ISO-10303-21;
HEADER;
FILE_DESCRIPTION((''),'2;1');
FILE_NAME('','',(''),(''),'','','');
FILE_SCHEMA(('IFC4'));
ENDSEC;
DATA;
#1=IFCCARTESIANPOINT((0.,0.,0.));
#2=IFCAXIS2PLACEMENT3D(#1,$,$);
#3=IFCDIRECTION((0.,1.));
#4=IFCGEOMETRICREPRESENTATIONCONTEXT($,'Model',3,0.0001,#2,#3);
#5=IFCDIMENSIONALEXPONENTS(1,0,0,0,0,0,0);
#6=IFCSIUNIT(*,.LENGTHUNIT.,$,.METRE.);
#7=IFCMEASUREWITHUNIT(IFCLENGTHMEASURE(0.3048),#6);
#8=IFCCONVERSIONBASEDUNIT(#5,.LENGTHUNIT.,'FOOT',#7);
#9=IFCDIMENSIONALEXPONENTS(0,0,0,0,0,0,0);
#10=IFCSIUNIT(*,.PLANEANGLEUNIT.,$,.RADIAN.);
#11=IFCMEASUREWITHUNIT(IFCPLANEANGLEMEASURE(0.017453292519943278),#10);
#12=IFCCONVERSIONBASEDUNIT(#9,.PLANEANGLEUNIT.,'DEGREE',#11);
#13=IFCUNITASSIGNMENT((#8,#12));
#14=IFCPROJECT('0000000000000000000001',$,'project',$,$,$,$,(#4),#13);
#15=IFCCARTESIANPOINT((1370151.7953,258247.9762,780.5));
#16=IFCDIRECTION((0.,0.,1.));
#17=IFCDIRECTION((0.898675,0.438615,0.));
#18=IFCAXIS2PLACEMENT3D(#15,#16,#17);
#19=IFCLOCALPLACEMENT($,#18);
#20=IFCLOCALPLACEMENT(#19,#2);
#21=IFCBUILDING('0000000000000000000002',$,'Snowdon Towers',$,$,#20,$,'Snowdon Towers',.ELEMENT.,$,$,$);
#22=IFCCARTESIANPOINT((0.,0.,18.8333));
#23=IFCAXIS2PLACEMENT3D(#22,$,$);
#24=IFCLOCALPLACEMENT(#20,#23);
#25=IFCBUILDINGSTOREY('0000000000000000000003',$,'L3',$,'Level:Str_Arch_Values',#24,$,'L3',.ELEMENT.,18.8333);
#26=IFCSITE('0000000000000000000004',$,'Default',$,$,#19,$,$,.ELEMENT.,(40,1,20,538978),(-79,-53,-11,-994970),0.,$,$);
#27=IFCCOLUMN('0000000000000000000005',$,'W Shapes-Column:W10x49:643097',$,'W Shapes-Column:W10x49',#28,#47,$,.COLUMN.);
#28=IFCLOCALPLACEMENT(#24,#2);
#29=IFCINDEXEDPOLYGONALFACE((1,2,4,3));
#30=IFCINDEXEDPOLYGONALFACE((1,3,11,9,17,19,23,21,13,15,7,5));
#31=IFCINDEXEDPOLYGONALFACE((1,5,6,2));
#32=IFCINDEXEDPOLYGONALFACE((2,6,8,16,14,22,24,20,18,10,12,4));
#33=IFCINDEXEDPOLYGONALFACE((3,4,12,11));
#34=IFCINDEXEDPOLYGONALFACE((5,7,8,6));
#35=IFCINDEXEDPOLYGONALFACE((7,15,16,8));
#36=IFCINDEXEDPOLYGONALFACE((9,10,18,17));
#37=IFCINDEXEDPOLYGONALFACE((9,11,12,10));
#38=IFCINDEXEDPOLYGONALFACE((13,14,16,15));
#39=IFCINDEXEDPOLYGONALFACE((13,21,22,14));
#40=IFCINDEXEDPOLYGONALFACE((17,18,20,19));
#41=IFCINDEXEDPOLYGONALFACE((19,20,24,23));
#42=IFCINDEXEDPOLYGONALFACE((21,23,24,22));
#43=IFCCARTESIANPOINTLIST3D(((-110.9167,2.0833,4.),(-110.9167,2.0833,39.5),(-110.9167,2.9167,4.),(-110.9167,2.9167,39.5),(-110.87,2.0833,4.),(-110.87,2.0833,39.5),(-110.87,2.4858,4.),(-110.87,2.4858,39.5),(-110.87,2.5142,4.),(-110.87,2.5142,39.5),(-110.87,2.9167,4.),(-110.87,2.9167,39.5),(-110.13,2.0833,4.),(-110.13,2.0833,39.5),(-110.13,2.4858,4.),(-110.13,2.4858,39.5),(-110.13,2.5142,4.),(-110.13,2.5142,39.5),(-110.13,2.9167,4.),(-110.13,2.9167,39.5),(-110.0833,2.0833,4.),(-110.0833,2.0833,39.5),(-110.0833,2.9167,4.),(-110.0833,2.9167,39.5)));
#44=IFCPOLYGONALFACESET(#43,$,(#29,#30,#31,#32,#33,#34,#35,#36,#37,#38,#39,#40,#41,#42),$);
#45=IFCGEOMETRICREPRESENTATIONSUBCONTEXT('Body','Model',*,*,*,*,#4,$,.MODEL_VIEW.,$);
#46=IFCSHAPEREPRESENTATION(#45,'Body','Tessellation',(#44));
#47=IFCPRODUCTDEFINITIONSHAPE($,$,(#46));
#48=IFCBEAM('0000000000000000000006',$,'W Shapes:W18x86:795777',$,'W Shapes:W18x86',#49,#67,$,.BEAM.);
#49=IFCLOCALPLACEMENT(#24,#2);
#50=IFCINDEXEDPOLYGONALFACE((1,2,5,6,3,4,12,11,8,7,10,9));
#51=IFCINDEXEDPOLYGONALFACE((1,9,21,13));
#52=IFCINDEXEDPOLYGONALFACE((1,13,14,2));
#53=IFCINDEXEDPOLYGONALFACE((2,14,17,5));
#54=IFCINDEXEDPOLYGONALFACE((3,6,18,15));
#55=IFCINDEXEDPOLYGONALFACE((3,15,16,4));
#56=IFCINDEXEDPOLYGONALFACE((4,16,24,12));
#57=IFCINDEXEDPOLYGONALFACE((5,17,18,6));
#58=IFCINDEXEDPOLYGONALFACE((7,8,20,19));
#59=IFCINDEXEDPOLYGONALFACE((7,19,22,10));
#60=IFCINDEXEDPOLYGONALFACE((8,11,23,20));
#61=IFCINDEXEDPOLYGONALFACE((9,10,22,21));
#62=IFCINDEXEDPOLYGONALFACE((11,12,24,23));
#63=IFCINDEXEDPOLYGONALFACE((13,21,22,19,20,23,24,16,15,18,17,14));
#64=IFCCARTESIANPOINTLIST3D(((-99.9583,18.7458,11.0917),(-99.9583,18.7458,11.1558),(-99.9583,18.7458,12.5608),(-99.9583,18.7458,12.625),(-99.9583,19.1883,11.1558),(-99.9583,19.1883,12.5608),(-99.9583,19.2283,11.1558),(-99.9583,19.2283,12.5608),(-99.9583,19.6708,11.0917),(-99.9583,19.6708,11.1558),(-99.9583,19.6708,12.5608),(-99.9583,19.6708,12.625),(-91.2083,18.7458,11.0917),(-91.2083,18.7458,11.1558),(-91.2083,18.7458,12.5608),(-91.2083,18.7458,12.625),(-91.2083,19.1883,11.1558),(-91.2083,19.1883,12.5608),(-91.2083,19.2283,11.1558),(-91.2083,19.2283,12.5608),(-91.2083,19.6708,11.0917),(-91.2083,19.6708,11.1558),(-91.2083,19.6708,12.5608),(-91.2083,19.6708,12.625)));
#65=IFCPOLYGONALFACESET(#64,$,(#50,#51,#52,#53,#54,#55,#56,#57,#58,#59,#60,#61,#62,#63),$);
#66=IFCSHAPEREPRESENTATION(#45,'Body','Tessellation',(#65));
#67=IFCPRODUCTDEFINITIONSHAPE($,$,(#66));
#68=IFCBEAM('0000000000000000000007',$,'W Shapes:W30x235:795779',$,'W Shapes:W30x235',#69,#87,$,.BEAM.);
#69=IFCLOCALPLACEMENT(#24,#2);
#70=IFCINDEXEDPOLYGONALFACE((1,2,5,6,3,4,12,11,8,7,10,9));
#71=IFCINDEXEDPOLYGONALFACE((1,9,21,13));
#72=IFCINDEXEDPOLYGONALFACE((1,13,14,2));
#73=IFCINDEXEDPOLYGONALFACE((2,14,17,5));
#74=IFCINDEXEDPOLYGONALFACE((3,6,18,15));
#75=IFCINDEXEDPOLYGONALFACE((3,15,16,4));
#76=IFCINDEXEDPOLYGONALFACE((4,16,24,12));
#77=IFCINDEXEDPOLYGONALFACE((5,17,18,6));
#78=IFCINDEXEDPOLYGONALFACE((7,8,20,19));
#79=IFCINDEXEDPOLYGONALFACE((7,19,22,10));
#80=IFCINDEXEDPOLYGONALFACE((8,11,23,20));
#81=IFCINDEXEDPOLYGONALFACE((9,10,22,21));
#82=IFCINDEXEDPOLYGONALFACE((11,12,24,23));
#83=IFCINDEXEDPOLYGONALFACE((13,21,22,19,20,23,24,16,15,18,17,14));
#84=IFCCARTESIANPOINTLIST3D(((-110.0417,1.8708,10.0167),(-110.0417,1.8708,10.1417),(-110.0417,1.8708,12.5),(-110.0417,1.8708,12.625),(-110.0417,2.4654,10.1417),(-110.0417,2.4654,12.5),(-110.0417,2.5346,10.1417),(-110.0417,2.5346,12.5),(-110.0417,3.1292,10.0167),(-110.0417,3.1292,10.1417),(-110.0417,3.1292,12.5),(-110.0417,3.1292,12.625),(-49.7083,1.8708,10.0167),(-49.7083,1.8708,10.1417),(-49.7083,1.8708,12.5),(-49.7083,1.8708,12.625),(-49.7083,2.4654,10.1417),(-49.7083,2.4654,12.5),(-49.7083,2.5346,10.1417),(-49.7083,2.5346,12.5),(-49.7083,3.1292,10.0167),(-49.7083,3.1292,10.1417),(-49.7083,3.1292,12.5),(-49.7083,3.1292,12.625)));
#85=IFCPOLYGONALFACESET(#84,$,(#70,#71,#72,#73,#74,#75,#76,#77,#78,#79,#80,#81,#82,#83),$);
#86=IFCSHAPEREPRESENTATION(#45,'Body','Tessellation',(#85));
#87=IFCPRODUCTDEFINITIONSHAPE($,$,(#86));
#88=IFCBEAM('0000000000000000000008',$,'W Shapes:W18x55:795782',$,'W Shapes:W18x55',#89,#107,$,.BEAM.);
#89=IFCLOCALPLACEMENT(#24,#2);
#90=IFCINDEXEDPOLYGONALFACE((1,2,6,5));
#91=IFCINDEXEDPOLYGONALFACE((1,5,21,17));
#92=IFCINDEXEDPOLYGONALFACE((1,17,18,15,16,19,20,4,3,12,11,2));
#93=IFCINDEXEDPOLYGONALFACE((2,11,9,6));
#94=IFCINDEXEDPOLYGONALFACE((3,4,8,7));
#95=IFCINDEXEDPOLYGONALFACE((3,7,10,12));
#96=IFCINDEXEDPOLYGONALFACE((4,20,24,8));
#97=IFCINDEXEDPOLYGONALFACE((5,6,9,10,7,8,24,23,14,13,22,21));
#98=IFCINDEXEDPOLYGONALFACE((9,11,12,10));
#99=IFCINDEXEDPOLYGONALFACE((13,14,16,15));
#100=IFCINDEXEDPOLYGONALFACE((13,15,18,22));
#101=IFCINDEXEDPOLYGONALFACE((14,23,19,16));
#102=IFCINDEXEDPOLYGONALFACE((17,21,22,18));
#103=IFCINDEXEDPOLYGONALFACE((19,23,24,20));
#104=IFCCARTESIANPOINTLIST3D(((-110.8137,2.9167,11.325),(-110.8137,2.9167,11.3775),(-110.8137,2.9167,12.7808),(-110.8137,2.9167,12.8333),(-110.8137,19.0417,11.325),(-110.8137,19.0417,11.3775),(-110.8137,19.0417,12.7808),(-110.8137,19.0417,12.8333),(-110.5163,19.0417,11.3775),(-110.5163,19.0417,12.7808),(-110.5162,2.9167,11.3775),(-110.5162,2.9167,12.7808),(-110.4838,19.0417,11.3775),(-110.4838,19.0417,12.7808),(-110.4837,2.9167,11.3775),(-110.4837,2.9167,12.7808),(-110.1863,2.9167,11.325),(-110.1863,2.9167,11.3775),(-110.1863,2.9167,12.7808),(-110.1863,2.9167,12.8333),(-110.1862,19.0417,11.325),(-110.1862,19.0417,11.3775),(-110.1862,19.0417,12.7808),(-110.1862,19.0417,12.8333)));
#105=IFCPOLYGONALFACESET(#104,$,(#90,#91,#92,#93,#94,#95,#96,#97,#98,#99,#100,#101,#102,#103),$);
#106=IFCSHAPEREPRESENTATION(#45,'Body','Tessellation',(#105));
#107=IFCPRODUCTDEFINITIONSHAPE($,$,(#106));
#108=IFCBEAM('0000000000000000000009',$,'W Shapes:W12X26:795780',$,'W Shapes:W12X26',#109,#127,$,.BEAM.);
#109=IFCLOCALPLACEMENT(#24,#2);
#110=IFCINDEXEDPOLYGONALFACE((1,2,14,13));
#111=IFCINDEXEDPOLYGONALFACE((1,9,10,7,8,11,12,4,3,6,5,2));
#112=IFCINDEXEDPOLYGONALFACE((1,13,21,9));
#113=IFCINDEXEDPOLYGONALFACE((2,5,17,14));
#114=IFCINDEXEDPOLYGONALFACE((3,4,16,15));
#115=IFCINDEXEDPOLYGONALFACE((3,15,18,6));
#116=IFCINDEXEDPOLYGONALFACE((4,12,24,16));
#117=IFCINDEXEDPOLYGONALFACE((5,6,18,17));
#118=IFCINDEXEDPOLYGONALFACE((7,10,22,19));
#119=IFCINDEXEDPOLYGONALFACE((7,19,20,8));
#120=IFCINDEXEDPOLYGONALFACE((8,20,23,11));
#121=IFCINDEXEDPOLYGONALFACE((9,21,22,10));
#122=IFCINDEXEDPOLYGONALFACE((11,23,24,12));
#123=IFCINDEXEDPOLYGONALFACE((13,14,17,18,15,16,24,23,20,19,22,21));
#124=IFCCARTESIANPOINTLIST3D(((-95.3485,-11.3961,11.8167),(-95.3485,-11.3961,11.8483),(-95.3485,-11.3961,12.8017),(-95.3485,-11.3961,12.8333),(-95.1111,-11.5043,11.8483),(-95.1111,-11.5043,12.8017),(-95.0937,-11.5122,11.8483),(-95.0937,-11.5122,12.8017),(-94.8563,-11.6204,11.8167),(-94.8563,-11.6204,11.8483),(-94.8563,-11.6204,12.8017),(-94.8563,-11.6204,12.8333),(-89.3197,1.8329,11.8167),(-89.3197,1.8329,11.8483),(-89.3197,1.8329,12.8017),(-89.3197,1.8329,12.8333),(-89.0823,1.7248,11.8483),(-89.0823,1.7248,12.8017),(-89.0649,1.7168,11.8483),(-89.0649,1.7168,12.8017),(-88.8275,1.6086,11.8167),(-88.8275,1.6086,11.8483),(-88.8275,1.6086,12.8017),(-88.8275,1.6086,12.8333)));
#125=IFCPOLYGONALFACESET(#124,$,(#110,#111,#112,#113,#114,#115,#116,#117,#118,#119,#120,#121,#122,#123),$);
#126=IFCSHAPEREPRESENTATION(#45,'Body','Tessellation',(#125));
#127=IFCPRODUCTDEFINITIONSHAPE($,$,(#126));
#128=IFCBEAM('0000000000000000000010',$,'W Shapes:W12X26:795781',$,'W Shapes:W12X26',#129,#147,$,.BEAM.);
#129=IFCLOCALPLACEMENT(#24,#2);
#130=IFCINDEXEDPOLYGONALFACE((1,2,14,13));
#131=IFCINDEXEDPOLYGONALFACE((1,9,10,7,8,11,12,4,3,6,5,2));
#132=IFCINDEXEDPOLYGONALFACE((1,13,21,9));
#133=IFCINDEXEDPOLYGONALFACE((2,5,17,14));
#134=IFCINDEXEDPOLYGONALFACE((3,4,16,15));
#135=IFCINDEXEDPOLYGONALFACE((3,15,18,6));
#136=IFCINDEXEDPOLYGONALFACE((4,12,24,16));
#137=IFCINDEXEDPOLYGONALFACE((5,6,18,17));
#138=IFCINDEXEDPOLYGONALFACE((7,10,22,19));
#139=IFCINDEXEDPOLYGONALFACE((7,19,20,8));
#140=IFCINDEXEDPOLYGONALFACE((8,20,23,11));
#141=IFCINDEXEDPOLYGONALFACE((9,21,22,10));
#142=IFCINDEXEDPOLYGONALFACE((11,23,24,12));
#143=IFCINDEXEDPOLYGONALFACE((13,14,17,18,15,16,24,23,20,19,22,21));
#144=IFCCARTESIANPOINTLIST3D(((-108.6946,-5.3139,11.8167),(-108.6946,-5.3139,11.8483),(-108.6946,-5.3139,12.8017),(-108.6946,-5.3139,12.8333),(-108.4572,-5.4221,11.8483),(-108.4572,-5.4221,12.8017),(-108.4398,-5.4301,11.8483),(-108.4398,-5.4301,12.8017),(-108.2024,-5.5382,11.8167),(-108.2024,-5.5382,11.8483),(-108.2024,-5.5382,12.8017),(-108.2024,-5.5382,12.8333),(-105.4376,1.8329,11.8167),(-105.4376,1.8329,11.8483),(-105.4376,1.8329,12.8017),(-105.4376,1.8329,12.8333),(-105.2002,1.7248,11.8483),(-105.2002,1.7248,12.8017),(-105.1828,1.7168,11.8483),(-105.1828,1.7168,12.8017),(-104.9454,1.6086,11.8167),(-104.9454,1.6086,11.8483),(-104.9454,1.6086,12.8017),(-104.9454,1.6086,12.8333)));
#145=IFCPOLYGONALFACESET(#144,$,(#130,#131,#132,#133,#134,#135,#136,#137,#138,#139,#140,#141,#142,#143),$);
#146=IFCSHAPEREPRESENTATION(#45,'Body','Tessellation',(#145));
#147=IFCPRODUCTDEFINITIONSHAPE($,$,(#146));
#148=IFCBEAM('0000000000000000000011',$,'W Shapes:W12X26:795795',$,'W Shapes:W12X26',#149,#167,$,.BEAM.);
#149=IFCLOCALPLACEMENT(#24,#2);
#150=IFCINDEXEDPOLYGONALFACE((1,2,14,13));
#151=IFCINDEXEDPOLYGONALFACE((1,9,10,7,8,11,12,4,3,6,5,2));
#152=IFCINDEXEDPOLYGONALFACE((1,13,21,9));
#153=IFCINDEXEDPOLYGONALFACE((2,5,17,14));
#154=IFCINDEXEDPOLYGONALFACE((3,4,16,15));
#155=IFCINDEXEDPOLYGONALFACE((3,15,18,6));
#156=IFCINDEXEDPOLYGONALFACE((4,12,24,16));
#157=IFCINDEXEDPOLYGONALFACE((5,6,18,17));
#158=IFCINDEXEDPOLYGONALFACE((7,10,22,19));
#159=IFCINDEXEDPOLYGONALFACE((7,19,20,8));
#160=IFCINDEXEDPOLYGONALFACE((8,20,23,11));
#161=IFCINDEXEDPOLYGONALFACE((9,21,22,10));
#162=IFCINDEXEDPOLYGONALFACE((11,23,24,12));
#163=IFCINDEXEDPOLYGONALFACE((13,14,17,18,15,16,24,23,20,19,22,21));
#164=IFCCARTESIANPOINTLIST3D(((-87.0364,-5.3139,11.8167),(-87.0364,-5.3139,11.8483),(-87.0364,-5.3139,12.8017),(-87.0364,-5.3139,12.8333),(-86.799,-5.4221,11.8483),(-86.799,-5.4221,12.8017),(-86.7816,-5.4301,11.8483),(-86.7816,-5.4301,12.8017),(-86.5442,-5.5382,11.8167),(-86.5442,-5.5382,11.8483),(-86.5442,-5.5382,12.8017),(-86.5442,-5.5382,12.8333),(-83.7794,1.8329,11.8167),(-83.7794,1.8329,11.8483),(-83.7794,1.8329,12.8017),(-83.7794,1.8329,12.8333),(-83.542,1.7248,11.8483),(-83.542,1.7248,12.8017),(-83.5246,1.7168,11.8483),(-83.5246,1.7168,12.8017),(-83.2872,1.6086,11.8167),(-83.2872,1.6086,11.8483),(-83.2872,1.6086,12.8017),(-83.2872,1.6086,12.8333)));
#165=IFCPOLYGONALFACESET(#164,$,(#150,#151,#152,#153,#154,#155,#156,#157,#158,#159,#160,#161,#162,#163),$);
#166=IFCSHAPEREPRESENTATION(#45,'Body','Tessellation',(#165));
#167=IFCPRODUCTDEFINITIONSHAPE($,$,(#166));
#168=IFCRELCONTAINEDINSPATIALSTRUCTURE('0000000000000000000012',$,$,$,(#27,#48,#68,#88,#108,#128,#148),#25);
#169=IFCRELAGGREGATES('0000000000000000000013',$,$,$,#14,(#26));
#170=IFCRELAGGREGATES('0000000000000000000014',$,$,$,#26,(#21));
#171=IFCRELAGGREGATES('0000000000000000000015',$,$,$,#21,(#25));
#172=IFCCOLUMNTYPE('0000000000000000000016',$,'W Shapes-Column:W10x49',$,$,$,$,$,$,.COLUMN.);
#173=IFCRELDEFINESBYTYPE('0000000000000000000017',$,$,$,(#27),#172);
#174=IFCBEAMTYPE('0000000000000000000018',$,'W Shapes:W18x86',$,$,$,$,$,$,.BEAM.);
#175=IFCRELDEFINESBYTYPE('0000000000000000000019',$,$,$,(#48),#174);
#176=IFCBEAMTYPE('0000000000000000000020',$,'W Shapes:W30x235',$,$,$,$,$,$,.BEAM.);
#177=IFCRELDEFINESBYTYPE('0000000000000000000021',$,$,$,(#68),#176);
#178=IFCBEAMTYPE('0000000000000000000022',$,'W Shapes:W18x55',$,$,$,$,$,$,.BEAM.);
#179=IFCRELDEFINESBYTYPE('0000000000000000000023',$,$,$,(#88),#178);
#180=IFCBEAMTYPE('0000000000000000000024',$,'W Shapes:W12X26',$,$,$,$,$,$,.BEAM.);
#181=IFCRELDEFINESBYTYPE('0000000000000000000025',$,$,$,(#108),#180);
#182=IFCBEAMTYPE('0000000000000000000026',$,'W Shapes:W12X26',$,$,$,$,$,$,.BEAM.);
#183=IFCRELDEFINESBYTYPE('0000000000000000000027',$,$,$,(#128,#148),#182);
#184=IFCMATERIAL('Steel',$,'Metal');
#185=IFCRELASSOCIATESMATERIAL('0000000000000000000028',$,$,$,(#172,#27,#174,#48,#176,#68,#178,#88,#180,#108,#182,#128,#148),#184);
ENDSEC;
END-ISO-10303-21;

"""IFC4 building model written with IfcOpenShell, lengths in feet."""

from ifc_helpers import new_model, entity, si_unit, converted_unit, direction, frame, origin, place, context, subcontext, project, spatial, indexed_curve, outline, extrude, source, transform, mapped, material, type_object, type_shapes, element, save


model = new_model("IFC4")

# Units and contexts
model_context = context("Model", 3, precision=0.0001, world=origin(), true_north=direction((0.0, 1.0)))
body_context = subcontext(model_context, "Body", "Model", "MODEL_VIEW")
ifc_project = project(units=[converted_unit("LENGTHUNIT", "FOOT", entity("IfcLengthMeasure", 0.3048), si_unit("LENGTHUNIT", "METRE"), dimensions=[1, 0, 0, 0, 0, 0, 0]), converted_unit("PLANEANGLEUNIT", "DEGREE", entity("IfcPlaneAngleMeasure", 0.017453292519943278), si_unit("PLANEANGLEUNIT", "RADIAN"), dimensions=[0, 0, 0, 0, 0, 0, 0])], contexts=[model_context])

# Site, building, storey
site_placement = place(None, frame((1370151.7953, 258247.9762, 780.5), z_axis=(0.0, 0.0, 1.0), x_axis=(0.898675, 0.438615, 0.0)))
site = spatial("IfcSite", under=ifc_project, at=site_placement, Name="Default", CompositionType="ELEMENT", RefLatitude=(40, 1, 20, 538978), RefLongitude=(-79, -53, -11, -994970), RefElevation=0.0)
building_placement = place(site_placement, origin())
building = spatial("IfcBuilding", under=site, at=building_placement, Name="Snowdon Towers", LongName="Snowdon Towers", CompositionType="ELEMENT")
storey_placement = place(building_placement, frame((0.0, 0.0, 18.8333)))
storey = spatial("IfcBuildingStorey", under=building, at=storey_placement, Name="L3", ObjectType="Level:Str_Arch_Values", LongName="L3", CompositionType="ELEMENT", Elevation=18.8333)

# Column
ifc_material = material(Name="Steel", Category="Metal")
column_type = type_object("IfcColumnType", Name="W Shapes-Column:W10x49", PredefinedType="COLUMN", material=ifc_material)
shared_shape_1 = source(origin(), body_context, "Body", "SweptSolid", [
    extrude(outline(indexed_curve([(-0.4167, -0.4167), (0.4167, -0.4167), (0.4167, -0.37), (0.0142, -0.37), (0.0142, 0.37), (0.4167, 0.37), (0.4167, 0.4167), (-0.4167, 0.4167), (-0.4167, 0.37), (-0.0142, 0.37), (-0.0142, -0.37), (-0.4167, -0.37), (-0.4167, -0.4167)], self_intersect=False)), frame((0.0, 0.0, 22.8333), z_axis=(0.0, 0.0, 1.0), x_axis=(-1.0, 0.0, 0.0)), (0.0, 0.0, 1.0), 35.5),
])
type_shapes(column_type, [shared_shape_1])
column_placement = place(storey_placement, frame((-110.5, 2.5, -18.8333), z_axis=(0.0, 0.0, 1.0), x_axis=(0.0, 1.0, 0.0)))
element("IfcColumn", 1, at=column_placement, inside=storey, type_object=column_type, material=ifc_material, Name="W Shapes-Column:W10x49:643097", ObjectType="W Shapes-Column:W10x49", PredefinedType="COLUMN", context=body_context, shape_type="MappedRepresentation", body=[
    mapped(shared_shape_1, transform((0.0, 0.0, 0.0), scale=1.0)),
])

# Beams
beam_type_1 = type_object("IfcBeamType", Name="W Shapes:W18x86", PredefinedType="BEAM", material=ifc_material)
shared_shape_2 = source(origin(), body_context, "Body", "SweptSolid", [
    extrude(outline(indexed_curve([(-0.4625, -0.7025), (-0.4625, -0.7667), (0.4625, -0.7667), (0.4625, -0.7025), (0.02, -0.7025), (0.02, 0.7025), (0.4625, 0.7025), (0.4625, 0.7667), (-0.4625, 0.7667), (-0.4625, 0.7025), (-0.02, 0.7025), (-0.02, -0.7025), (-0.4625, -0.7025)], self_intersect=False)), frame((-4.6042, 0.0, 0.0), z_axis=(-1.0, 0.0, 0.0), x_axis=(0.0, -1.0, 0.0)), (0.0, 0.0, -1.0), 8.75),
])
type_shapes(beam_type_1, [shared_shape_2])
beam_1_placement = place(storey_placement, frame((-95.3542, 19.2083, 11.8583)))
element("IfcBeam", 2, at=beam_1_placement, inside=storey, type_object=beam_type_1, material=ifc_material, Name="W Shapes:W18x86:795777", ObjectType="W Shapes:W18x86", PredefinedType="BEAM", context=body_context, shape_type="MappedRepresentation", body=[
    mapped(shared_shape_2, transform((0.0, 0.0, 0.0), scale=1.0)),
])
beam_type_2 = type_object("IfcBeamType", Name="W Shapes:W30x235", PredefinedType="BEAM", material=ifc_material)
shared_shape_3 = source(origin(), body_context, "Body", "SweptSolid", [
    extrude(outline(indexed_curve([(-0.6292, -1.1792), (-0.6292, -1.3042), (0.6292, -1.3042), (0.6292, -1.1792), (0.0346, -1.1792), (0.0346, 1.1792), (0.6292, 1.1792), (0.6292, 1.3042), (-0.6292, 1.3042), (-0.6292, 1.1792), (-0.0346, 1.1792), (-0.0346, -1.1792), (-0.6292, -1.1792)], self_intersect=False)), frame((-29.9167, 0.0, 0.0), z_axis=(-1.0, 0.0, 0.0), x_axis=(0.0, -1.0, 0.0)), (0.0, 0.0, -1.0), 60.3333),
])
type_shapes(beam_type_2, [shared_shape_3])
beam_2_placement = place(storey_placement, frame((-80.125, 2.5, 11.3208)))
element("IfcBeam", 3, at=beam_2_placement, inside=storey, type_object=beam_type_2, material=ifc_material, Name="W Shapes:W30x235:795779", ObjectType="W Shapes:W30x235", PredefinedType="BEAM", context=body_context, shape_type="MappedRepresentation", body=[
    mapped(shared_shape_3, transform((0.0, 0.0, 0.0), scale=1.0)),
])
beam_type_3 = type_object("IfcBeamType", Name="W Shapes:W18x55", PredefinedType="BEAM", material=ifc_material)
shared_shape_4 = source(origin(), body_context, "Body", "SweptSolid", [
    extrude(outline(indexed_curve([(-0.3138, -0.7017), (-0.3138, -0.7542), (0.3138, -0.7542), (0.3138, -0.7017), (0.0162, -0.7017), (0.0162, 0.7017), (0.3138, 0.7017), (0.3138, 0.7542), (-0.3137, 0.7542), (-0.3137, 0.7017), (-0.0163, 0.7017), (-0.0163, -0.7017), (-0.3138, -0.7017)], self_intersect=False)), frame((-7.8542, 0.0, 0.0), z_axis=(-1.0, 0.0, 0.0), x_axis=(0.0, -1.0, 0.0)), (0.0, 0.0, -1.0), 16.125),
])
type_shapes(beam_type_3, [shared_shape_4])
beam_3_placement = place(storey_placement, frame((-110.5, 10.7708, 12.0792), z_axis=(0.0, 0.0, 1.0), x_axis=(0.0, 1.0, 0.0)))
element("IfcBeam", 4, at=beam_3_placement, inside=storey, type_object=beam_type_3, material=ifc_material, Name="W Shapes:W18x55:795782", ObjectType="W Shapes:W18x55", PredefinedType="BEAM", context=body_context, shape_type="MappedRepresentation", body=[
    mapped(shared_shape_4, transform((0.0, 0.0, 0.0), scale=1.0)),
])

# Beams
beam_type_4 = type_object("IfcBeamType", Name="W Shapes:W12X26", PredefinedType="BEAM", material=ifc_material)
shared_shape_5 = source(origin(), body_context, "Body", "SweptSolid", [
    extrude(outline(indexed_curve([(-0.2704, -0.4767), (-0.2704, -0.5083), (0.2704, -0.5083), (0.2704, -0.4767), (0.0096, -0.4767), (0.0096, 0.4767), (0.2704, 0.4767), (0.2704, 0.5083), (-0.2704, 0.5083), (-0.2704, 0.4767), (-0.0096, 0.4767), (-0.0096, -0.4767), (-0.2704, -0.4767)], self_intersect=False)), frame((-7.5411, 0.0, 0.0), z_axis=(-1.0, 0.0, 0.0), x_axis=(0.0, -1.0, 0.0)), (0.0, 0.0, -1.0), 14.538),
])
type_shapes(beam_type_4, [shared_shape_5])
beam_4_placement = place(storey_placement, frame((-91.9752, -4.6461, 12.325), z_axis=(0.0, 0.0, 1.0), x_axis=(0.414693, 0.909961, 0.0)))
element("IfcBeam", 5, at=beam_4_placement, inside=storey, type_object=beam_type_4, material=ifc_material, Name="W Shapes:W12X26:795780", ObjectType="W Shapes:W12X26", PredefinedType="BEAM", context=body_context, shape_type="MappedRepresentation", body=[
    mapped(shared_shape_5, transform((0.0, 0.0, 0.0), scale=1.0)),
])
beam_type_5 = type_object("IfcBeamType", Name="W Shapes:W12X26", PredefinedType="BEAM", material=ifc_material)
shared_shape_6 = source(origin(), body_context, "Body", "SweptSolid", [
    extrude(outline(indexed_curve([(-0.2704, -0.4767), (-0.2704, -0.5083), (0.2704, -0.5083), (0.2704, -0.4767), (0.0096, -0.4767), (0.0096, 0.4767), (0.2704, 0.4767), (0.2704, 0.5083), (-0.2704, 0.5083), (-0.2704, 0.4767), (-0.0096, 0.4767), (-0.0096, -0.4767), (-0.2704, -0.4767)], self_intersect=False)), frame((-4.1991, 0.0, 0.0), z_axis=(-1.0, 0.0, 0.0), x_axis=(0.0, -1.0, 0.0)), (0.0, 0.0, -1.0), 7.854),
])
type_shapes(beam_type_5, [shared_shape_6])
for number, where, z_axis, x_axis, name in (
    (6, (-106.7072, -1.605, 12.325), (0.0, 0.0, 1.0), (0.414693, 0.909961, 0.0), "W Shapes:W12X26:795781"),
    (7, (-85.0489, -1.605, 12.325), (0.0, 0.0, 1.0), (0.414693, 0.909961, 0.0), "W Shapes:W12X26:795795"),
):
    element("IfcBeam", number, at=place(storey_placement, frame(where, z_axis=z_axis, x_axis=x_axis)), inside=storey, type_object=beam_type_5, material=ifc_material, Name=name, ObjectType="W Shapes:W12X26", PredefinedType="BEAM", context=body_context, shape_type="MappedRepresentation", body=[
        mapped(shared_shape_6, transform((0.0, 0.0, 0.0), scale=1.0)),
    ])

save(model, "model.ifc")
